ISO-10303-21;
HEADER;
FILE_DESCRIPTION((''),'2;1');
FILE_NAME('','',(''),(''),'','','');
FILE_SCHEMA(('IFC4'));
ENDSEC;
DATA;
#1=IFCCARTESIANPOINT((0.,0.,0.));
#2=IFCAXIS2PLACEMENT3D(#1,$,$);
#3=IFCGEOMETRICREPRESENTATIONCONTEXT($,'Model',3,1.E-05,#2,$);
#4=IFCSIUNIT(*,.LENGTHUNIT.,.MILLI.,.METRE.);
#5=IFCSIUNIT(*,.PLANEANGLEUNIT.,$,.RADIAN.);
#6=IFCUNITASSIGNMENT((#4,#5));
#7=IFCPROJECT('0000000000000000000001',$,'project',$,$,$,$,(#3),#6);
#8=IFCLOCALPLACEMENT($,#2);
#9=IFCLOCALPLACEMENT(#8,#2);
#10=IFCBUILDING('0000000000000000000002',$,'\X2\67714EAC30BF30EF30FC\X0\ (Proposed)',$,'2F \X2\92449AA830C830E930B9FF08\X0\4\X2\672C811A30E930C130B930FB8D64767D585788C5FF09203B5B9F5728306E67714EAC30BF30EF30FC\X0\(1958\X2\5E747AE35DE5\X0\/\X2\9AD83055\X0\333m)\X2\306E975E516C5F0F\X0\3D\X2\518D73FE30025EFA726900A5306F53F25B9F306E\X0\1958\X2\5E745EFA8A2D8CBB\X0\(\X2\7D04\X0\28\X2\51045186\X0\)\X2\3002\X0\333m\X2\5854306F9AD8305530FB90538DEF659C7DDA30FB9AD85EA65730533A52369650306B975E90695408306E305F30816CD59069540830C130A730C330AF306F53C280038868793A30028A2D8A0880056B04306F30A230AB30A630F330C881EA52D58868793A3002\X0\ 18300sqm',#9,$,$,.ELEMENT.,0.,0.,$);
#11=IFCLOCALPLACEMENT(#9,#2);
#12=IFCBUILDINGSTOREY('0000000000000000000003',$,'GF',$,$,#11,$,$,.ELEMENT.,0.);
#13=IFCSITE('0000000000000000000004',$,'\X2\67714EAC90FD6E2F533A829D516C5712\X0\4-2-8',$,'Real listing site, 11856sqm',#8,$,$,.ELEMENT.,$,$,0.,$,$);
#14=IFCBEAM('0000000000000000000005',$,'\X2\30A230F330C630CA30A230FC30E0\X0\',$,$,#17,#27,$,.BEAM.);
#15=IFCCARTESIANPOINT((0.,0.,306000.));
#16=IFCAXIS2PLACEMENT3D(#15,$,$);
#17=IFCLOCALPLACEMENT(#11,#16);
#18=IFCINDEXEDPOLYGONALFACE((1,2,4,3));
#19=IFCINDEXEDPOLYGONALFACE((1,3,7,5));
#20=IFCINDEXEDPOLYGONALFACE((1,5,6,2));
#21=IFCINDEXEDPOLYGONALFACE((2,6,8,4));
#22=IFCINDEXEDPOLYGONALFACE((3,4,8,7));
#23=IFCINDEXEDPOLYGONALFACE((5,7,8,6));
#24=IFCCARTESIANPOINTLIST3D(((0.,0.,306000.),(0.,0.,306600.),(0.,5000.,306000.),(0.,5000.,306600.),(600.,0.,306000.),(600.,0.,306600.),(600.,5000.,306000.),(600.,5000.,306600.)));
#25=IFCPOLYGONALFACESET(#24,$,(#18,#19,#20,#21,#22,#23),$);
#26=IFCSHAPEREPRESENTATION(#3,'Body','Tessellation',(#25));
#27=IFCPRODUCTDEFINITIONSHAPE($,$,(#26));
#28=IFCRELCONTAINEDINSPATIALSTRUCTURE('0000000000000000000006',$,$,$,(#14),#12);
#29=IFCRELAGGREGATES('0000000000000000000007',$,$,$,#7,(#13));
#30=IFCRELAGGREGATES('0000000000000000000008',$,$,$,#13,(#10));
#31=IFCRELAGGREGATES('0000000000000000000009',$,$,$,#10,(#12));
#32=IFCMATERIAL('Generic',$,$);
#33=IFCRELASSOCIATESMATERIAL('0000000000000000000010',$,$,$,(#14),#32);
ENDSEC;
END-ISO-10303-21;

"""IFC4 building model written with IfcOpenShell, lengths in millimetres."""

from ifc_helpers import new_model, si_unit, frame, frame_2d, origin, place, context, project, spatial, rectangle, extrude, material, element, save


model = new_model("IFC4")

# Units and contexts
model_context = context("Model", 3, precision=1e-05, world=origin())
ifc_project = project(units=[si_unit("LENGTHUNIT", "METRE", prefix="MILLI"), si_unit("PLANEANGLEUNIT", "RADIAN")], contexts=[model_context])

# Site, building, storey
site_placement = place(None, origin())
site = spatial("IfcSite", under=ifc_project, at=site_placement, Name="東京都港区芝公園4-2-8", ObjectType="Real listing site, 11856sqm", CompositionType="ELEMENT", RefElevation=0.0)
building_placement = place(site_placement, origin())
building = spatial("IfcBuilding", under=site, at=building_placement, Name="東京タワー (Proposed)", ObjectType="2F 鉄骨トラス（4本脚ラチス・赤白塗装）※実在の東京タワー(1958年竣工/高さ333m)の非公式3D再現。建物¥は史実の1958年建設費(約28億円)。333m塔は高さ・道路斜線・高度地区制限に非適合のため法適合チェックは参考表示。設計者欄はアカウント自動表示。 18300sqm", CompositionType="ELEMENT", ElevationOfRefHeight=0.0, ElevationOfTerrain=0.0)
storey_placement = place(building_placement, origin())
storey = spatial("IfcBuildingStorey", under=building, at=storey_placement, Name="GF", CompositionType="ELEMENT", Elevation=0.0)

# Shared definitions
ifc_material = material(Name="Generic")

# Beam
beam_1_placement = place(storey_placement, frame((0.0, 0.0, 306000.0)))
element("IfcBeam", 1, at=beam_1_placement, inside=storey, material=ifc_material, Name="アンテナアーム", PredefinedType="BEAM", context=model_context, shape_type="SweptSolid", body=[
    extrude(rectangle(XDim=600.0, YDim=5000.0, at=frame_2d((300.0, 2500.0))), frame((0.0, 0.0, 306000.0)), (0.0, 0.0, 1.0), 600.0),
])

save(model, "model.ifc")
